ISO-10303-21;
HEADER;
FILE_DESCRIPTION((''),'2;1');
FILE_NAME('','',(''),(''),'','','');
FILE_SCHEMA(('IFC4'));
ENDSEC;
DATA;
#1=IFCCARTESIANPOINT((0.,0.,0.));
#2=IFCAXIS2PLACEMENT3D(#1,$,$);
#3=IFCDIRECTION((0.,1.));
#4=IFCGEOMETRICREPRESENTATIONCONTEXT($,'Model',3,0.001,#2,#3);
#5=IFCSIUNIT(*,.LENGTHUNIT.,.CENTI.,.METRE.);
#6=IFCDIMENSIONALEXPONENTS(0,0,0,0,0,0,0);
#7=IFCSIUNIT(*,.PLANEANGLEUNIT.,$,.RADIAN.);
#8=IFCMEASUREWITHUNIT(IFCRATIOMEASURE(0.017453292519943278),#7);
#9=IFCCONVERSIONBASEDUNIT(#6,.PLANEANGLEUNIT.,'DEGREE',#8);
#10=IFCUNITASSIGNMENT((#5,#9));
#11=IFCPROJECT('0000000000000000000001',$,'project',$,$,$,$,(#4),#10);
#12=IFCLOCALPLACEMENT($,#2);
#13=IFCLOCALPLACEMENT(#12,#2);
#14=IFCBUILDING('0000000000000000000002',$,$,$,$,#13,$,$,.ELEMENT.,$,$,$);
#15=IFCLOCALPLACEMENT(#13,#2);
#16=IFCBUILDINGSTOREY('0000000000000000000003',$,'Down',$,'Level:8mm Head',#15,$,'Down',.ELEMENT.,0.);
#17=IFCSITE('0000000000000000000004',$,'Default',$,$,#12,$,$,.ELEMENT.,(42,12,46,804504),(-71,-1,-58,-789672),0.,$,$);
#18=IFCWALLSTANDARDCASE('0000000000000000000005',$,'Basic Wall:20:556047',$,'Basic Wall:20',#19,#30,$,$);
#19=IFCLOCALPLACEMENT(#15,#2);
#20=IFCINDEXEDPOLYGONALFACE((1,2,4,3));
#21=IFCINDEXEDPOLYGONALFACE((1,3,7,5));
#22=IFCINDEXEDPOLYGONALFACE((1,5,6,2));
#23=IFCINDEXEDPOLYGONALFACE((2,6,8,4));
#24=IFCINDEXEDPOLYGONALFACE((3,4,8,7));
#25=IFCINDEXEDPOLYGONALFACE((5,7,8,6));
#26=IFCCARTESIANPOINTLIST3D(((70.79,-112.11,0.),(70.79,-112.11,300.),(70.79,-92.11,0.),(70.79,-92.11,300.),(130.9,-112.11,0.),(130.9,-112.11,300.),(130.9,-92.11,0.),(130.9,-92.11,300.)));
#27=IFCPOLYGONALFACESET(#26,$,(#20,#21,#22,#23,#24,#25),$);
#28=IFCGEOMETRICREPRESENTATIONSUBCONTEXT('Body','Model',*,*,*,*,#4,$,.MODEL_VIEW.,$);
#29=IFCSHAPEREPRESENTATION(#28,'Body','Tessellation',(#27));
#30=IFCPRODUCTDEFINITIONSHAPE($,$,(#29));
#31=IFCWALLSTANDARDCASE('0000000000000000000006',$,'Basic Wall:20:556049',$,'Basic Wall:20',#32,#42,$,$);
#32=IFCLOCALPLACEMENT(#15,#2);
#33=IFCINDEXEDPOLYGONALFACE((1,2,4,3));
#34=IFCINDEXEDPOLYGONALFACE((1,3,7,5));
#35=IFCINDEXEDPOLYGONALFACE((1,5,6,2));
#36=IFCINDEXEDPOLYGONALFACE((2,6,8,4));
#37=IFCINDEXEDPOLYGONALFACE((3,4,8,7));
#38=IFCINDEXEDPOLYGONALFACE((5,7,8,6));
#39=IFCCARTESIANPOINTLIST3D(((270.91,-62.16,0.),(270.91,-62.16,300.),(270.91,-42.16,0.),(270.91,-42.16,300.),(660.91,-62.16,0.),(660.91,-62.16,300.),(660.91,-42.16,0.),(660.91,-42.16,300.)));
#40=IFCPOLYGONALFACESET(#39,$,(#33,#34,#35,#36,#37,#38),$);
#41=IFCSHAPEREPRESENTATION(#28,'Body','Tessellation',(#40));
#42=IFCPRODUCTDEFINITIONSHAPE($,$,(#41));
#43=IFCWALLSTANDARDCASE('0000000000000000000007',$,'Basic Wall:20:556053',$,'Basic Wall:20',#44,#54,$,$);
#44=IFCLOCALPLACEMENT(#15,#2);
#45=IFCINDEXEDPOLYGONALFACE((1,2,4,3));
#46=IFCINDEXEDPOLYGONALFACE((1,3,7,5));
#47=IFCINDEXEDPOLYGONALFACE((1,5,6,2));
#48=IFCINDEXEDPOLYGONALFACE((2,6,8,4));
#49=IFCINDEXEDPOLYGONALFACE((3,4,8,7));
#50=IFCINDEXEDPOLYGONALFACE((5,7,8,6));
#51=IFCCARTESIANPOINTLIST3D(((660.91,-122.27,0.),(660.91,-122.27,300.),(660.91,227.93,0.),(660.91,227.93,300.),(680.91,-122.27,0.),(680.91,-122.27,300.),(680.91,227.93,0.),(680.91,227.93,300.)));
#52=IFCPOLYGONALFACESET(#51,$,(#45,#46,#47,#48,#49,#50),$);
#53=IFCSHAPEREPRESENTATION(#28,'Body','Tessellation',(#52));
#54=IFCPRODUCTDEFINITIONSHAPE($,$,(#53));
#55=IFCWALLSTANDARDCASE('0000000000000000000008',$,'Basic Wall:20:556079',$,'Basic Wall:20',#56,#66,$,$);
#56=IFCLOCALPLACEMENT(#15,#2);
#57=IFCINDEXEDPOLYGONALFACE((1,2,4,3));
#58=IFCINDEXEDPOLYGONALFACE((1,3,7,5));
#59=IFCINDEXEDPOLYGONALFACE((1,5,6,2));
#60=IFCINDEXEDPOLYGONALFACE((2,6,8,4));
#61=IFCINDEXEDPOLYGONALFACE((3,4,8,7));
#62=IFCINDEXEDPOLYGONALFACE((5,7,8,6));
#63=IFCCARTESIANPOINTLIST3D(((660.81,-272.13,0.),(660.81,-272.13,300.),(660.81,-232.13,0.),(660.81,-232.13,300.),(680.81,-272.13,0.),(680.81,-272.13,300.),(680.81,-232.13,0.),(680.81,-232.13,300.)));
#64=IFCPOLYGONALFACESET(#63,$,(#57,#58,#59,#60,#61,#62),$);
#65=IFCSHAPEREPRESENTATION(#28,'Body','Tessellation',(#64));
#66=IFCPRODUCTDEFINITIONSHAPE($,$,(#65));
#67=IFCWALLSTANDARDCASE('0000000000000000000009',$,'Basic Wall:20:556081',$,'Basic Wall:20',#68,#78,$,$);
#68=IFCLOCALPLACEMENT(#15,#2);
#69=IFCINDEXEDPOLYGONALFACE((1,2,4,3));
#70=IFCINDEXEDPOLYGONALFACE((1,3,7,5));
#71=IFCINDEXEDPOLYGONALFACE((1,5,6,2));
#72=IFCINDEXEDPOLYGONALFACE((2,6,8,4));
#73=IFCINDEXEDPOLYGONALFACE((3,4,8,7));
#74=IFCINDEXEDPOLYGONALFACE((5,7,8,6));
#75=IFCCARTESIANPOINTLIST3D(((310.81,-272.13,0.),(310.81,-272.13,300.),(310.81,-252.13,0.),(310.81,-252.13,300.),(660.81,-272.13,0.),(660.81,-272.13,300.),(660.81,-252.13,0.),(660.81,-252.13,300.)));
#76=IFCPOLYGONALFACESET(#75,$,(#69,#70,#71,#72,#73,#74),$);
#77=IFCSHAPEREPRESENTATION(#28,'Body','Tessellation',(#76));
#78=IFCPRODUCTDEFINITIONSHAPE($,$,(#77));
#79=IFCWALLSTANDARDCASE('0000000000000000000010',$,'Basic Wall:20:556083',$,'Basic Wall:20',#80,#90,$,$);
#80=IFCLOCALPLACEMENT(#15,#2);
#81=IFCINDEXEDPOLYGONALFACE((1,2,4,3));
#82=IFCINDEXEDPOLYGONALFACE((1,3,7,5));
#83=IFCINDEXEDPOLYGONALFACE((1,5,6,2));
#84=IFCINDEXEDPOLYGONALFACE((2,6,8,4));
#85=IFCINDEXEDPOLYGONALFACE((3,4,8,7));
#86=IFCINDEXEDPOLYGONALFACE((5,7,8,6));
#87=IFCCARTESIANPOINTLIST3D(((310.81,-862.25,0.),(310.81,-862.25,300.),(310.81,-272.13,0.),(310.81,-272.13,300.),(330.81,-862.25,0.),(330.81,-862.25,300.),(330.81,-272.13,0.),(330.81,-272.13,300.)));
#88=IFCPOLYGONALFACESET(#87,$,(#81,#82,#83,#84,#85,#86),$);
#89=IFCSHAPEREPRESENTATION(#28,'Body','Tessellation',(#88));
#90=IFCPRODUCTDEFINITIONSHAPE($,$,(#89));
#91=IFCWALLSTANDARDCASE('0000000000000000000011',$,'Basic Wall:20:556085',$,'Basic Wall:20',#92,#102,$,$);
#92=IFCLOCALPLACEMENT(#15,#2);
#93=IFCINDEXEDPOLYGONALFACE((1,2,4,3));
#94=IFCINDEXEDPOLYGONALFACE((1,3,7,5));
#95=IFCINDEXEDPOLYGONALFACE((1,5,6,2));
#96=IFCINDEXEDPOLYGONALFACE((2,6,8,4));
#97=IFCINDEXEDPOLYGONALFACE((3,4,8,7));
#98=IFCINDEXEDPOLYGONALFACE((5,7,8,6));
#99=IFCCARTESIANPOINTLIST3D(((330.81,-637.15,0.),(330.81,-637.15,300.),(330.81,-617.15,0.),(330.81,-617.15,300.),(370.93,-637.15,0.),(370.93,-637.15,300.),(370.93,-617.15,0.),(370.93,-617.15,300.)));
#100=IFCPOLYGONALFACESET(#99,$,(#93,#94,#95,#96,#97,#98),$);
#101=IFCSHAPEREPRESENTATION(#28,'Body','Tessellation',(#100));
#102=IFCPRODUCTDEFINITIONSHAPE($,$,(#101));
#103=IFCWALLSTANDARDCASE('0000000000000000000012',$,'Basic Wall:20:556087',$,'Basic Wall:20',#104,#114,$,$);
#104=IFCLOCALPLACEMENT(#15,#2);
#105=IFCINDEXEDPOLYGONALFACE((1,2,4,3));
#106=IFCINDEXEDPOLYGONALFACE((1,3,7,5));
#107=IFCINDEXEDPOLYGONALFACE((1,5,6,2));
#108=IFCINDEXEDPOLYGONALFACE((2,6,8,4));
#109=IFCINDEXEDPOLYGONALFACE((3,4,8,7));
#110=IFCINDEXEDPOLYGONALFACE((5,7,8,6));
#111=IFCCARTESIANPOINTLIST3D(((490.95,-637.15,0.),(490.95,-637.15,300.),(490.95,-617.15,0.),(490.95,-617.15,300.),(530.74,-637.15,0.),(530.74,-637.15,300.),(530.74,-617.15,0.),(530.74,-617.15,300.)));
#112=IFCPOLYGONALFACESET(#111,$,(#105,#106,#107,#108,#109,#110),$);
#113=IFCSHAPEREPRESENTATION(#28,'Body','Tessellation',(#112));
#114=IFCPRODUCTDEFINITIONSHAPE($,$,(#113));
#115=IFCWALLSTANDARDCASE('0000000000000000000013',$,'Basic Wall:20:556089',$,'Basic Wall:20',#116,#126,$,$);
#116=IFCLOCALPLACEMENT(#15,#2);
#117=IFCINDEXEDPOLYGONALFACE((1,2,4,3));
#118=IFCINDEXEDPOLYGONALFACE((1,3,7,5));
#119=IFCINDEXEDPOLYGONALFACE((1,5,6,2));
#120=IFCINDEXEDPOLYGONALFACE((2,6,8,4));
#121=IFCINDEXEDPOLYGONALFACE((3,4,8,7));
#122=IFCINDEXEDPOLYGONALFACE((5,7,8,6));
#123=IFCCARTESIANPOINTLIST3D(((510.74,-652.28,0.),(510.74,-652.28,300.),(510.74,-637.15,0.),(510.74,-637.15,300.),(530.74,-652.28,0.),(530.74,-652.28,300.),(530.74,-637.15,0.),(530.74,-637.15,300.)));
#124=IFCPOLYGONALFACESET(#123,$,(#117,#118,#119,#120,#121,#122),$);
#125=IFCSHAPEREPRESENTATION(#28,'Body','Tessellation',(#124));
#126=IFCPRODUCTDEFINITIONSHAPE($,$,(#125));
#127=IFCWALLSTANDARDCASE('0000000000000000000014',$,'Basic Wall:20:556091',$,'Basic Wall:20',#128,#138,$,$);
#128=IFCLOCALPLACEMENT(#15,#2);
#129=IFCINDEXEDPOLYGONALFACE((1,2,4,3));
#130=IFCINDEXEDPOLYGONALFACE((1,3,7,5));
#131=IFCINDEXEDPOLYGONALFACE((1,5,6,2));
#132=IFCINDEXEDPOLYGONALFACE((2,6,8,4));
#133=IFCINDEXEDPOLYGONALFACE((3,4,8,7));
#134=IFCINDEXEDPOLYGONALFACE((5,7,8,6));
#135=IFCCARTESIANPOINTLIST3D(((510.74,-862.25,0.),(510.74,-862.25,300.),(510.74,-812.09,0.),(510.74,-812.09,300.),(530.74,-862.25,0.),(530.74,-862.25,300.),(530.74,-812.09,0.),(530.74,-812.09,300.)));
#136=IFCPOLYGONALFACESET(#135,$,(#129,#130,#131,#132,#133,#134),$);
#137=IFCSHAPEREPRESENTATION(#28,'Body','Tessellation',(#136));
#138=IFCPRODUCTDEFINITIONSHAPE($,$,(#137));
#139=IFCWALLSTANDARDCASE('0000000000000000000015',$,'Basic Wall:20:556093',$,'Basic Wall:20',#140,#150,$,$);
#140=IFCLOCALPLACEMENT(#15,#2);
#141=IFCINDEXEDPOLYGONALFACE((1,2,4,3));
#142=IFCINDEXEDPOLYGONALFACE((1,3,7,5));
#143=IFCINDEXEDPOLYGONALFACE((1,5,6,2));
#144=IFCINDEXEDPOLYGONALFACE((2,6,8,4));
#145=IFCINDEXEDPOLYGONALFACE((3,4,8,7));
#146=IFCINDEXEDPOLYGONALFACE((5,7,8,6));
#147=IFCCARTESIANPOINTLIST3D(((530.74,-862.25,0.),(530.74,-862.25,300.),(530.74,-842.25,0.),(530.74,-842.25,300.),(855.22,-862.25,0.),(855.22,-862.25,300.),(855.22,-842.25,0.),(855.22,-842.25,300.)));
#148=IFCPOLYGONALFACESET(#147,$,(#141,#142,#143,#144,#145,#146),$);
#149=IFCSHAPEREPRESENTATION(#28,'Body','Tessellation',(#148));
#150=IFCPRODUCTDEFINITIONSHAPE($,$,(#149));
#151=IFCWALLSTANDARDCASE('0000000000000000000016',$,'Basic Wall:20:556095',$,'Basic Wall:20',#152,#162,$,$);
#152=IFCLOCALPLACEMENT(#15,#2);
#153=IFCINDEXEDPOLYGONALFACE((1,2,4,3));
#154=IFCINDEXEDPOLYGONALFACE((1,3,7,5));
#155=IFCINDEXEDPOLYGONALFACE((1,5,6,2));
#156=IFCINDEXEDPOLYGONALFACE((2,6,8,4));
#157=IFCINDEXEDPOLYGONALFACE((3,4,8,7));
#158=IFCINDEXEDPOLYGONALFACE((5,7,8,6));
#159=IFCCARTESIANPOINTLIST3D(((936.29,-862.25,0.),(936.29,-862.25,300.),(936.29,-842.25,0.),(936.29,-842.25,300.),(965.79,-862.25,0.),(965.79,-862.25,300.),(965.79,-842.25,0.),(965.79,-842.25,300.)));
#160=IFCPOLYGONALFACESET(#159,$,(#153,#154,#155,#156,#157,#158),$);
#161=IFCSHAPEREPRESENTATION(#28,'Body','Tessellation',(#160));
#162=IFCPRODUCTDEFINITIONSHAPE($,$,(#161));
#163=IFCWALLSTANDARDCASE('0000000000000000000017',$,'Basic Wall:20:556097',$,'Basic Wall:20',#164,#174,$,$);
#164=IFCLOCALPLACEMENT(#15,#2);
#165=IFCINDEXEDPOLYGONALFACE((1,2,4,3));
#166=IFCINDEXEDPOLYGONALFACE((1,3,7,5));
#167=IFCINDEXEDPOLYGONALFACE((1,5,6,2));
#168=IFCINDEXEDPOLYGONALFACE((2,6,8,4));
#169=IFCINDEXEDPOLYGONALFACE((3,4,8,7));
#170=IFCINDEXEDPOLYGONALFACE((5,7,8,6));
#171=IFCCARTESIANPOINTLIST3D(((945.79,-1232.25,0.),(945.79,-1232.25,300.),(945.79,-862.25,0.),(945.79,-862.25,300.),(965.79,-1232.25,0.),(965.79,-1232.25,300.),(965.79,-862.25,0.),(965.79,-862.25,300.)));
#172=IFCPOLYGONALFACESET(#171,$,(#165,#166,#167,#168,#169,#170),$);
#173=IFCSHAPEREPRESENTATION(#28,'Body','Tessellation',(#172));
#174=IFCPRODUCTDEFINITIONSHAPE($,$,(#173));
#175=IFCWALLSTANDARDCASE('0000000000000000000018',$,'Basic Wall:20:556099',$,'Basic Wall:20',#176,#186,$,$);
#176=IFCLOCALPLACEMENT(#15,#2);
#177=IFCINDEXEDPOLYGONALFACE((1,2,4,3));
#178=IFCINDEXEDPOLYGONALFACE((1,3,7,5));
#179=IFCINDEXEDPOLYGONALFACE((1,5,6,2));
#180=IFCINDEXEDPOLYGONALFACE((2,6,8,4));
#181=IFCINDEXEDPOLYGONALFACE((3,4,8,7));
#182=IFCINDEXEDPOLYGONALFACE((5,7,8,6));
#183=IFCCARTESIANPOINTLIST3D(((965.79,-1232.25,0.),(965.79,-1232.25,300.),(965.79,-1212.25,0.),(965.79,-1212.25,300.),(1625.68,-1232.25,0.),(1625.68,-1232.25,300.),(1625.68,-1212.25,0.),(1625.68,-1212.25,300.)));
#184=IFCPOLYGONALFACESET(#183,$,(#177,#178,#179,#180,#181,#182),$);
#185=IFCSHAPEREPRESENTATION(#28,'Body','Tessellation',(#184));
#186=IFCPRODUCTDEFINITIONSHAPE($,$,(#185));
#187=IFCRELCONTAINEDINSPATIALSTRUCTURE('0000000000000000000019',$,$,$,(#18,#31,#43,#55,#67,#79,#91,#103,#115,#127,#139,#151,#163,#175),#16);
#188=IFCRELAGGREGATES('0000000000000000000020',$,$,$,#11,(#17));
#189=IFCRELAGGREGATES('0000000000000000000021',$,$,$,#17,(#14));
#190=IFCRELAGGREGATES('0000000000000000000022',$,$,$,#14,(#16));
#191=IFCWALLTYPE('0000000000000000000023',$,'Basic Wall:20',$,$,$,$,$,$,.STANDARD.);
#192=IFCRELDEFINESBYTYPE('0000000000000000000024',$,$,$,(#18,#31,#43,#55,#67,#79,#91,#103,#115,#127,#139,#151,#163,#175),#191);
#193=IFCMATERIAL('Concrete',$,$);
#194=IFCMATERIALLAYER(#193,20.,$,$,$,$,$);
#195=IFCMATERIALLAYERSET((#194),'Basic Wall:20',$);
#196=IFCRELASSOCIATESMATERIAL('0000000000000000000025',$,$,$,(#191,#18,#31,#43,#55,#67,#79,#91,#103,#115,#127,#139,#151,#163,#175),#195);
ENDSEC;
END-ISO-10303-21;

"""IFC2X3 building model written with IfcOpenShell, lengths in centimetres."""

from ifc_helpers import new_model, entity, si_unit, converted_unit, direction, frame, frame_2d, origin, place, context, subcontext, project, spatial, rectangle, extrude, material, layer, layer_set, layer_usage, type_object, element, save


model = new_model("IFC2X3")

# Units and contexts
model_context = context("Model", 3, precision=0.001, world=origin(), true_north=direction((0.0, 1.0)))
body_context = subcontext(model_context, "Body", "Model", "MODEL_VIEW")
ifc_project = project(units=[si_unit("LENGTHUNIT", "METRE", prefix="CENTI"), converted_unit("PLANEANGLEUNIT", "DEGREE", entity("IfcRatioMeasure", 0.017453292519943278), si_unit("PLANEANGLEUNIT", "RADIAN"), dimensions=[0, 0, 0, 0, 0, 0, 0])], contexts=[model_context])

# Site, building, storey
site_placement = place(None, origin())
site = spatial("IfcSite", under=ifc_project, at=site_placement, Name="Default", CompositionType="ELEMENT", RefLatitude=(42, 12, 46, 804504), RefLongitude=(-71, -1, -58, -789672), RefElevation=0.0)
building_placement = place(site_placement, origin())
building = spatial("IfcBuilding", under=site, at=building_placement, CompositionType="ELEMENT")
storey_placement = place(building_placement, origin())
storey = spatial("IfcBuildingStorey", under=building, at=storey_placement, Name="Down", ObjectType="Level:8mm Head", LongName="Down", CompositionType="ELEMENT", Elevation=0.0)

# Walls
ifc_material = material(Name="Concrete")
ifc_layer_1 = layer(ifc_material, 20.0)
ifc_layer_set_1 = layer_set([ifc_layer_1], Name="Basic Wall:20")
ifc_layer_usage_1 = layer_usage(ifc_layer_set_1, "AXIS2", "NEGATIVE", 10.0)
wall_type_1 = type_object("IfcWallType", Name="Basic Wall:20", PredefinedType="STANDARD", material=ifc_layer_set_1)
wall_1_placement = place(storey_placement, frame((130.9, -102.11, 0.0), z_axis=(0.0, 0.0, 1.0), x_axis=(-1.0, 0.0, 0.0)))
element("IfcWallStandardCase", 1, at=wall_1_placement, inside=storey, type_object=wall_type_1, material=ifc_layer_usage_1, Name="Basic Wall:20:556047", ObjectType="Basic Wall:20", context=body_context, shape_type="SweptSolid", body=[
    extrude(rectangle(XDim=60.11, YDim=20.0, at=frame_2d((30.06, 0.0), x_axis=(-1.0, 0.0))), origin(), (0.0, 0.0, 1.0), 300.0),
])
ifc_layer_usage_2 = layer_usage(ifc_layer_set_1, "AXIS2", "POSITIVE", -10.0)
wall_2_placement = place(storey_placement, frame((270.91, -52.16, 0.0)))
element("IfcWallStandardCase", 2, at=wall_2_placement, inside=storey, type_object=wall_type_1, material=ifc_layer_usage_2, Name="Basic Wall:20:556049", ObjectType="Basic Wall:20", context=body_context, shape_type="SweptSolid", body=[
    extrude(rectangle(XDim=390.0, YDim=20.0, at=frame_2d((195.0, 0.0), x_axis=(-1.0, 0.0))), origin(), (0.0, 0.0, 1.0), 300.0),
])
ifc_layer_usage_3 = layer_usage(ifc_layer_set_1, "AXIS2", "POSITIVE", -10.0)
wall_3_placement = place(storey_placement, frame((670.91, -122.27, 0.0), z_axis=(0.0, 0.0, 1.0), x_axis=(0.0, 1.0, 0.0)))
element("IfcWallStandardCase", 3, at=wall_3_placement, inside=storey, type_object=wall_type_1, material=ifc_layer_usage_3, Name="Basic Wall:20:556053", ObjectType="Basic Wall:20", context=body_context, shape_type="SweptSolid", body=[
    extrude(rectangle(XDim=350.2, YDim=20.0, at=frame_2d((175.1, 0.0), x_axis=(-1.0, 0.0))), origin(), (0.0, 0.0, 1.0), 300.0),
])
ifc_layer_usage_4 = layer_usage(ifc_layer_set_1, "AXIS2", "NEGATIVE", 10.0)
wall_4_placement = place(storey_placement, frame((670.81, -232.13, 0.0), z_axis=(0.0, 0.0, 1.0), x_axis=(0.0, -1.0, 0.0)))
element("IfcWallStandardCase", 4, at=wall_4_placement, inside=storey, type_object=wall_type_1, material=ifc_layer_usage_4, Name="Basic Wall:20:556079", ObjectType="Basic Wall:20", context=body_context, shape_type="SweptSolid", body=[
    extrude(rectangle(XDim=40.0, YDim=20.0, at=frame_2d((20.0, 0.0), x_axis=(-1.0, 0.0))), origin(), (0.0, 0.0, 1.0), 300.0),
])
ifc_layer_usage_5 = layer_usage(ifc_layer_set_1, "AXIS2", "NEGATIVE", 10.0)
wall_5_placement = place(storey_placement, frame((660.81, -262.13, 0.0), z_axis=(0.0, 0.0, 1.0), x_axis=(-1.0, 0.0, 0.0)))
element("IfcWallStandardCase", 5, at=wall_5_placement, inside=storey, type_object=wall_type_1, material=ifc_layer_usage_5, Name="Basic Wall:20:556081", ObjectType="Basic Wall:20", context=body_context, shape_type="SweptSolid", body=[
    extrude(rectangle(XDim=350.0, YDim=20.0, at=frame_2d((175.0, 0.0), x_axis=(-1.0, 0.0))), origin(), (0.0, 0.0, 1.0), 300.0),
])
ifc_layer_usage_6 = layer_usage(ifc_layer_set_1, "AXIS2", "POSITIVE", -10.0)
wall_6_placement = place(storey_placement, frame((320.81, -272.13, 0.0), z_axis=(0.0, 0.0, 1.0), x_axis=(0.0, -1.0, 0.0)))
element("IfcWallStandardCase", 6, at=wall_6_placement, inside=storey, type_object=wall_type_1, material=ifc_layer_usage_6, Name="Basic Wall:20:556083", ObjectType="Basic Wall:20", context=body_context, shape_type="SweptSolid", body=[
    extrude(rectangle(XDim=590.12, YDim=20.0, at=frame_2d((295.06, 0.0), x_axis=(-1.0, 0.0))), origin(), (0.0, 0.0, 1.0), 300.0),
])
ifc_layer_usage_7 = layer_usage(ifc_layer_set_1, "AXIS2", "NEGATIVE", 10.0)
wall_7_placement = place(storey_placement, frame((330.81, -627.15, 0.0)))
element("IfcWallStandardCase", 7, at=wall_7_placement, inside=storey, type_object=wall_type_1, material=ifc_layer_usage_7, Name="Basic Wall:20:556085", ObjectType="Basic Wall:20", context=body_context, shape_type="SweptSolid", body=[
    extrude(rectangle(XDim=40.12, YDim=20.0, at=frame_2d((20.06, 0.0), x_axis=(-1.0, 0.0))), origin(), (0.0, 0.0, 1.0), 300.0),
])
ifc_layer_usage_8 = layer_usage(ifc_layer_set_1, "AXIS2", "NEGATIVE", 10.0)
wall_8_placement = place(storey_placement, frame((490.95, -627.15, 0.0)))
element("IfcWallStandardCase", 8, at=wall_8_placement, inside=storey, type_object=wall_type_1, material=ifc_layer_usage_8, Name="Basic Wall:20:556087", ObjectType="Basic Wall:20", context=body_context, shape_type="SweptSolid", body=[
    extrude(rectangle(XDim=39.79, YDim=20.0, at=frame_2d((19.9, 0.0), x_axis=(-1.0, 0.0))), origin(), (0.0, 0.0, 1.0), 300.0),
])
ifc_layer_usage_9 = layer_usage(ifc_layer_set_1, "AXIS2", "NEGATIVE", 10.0)
wall_9_placement = place(storey_placement, frame((520.74, -637.15, 0.0), z_axis=(0.0, 0.0, 1.0), x_axis=(0.0, -1.0, 0.0)))
element("IfcWallStandardCase", 9, at=wall_9_placement, inside=storey, type_object=wall_type_1, material=ifc_layer_usage_9, Name="Basic Wall:20:556089", ObjectType="Basic Wall:20", context=body_context, shape_type="SweptSolid", body=[
    extrude(rectangle(XDim=15.14, YDim=20.0, at=frame_2d((7.57, 0.0), x_axis=(-1.0, 0.0))), origin(), (0.0, 0.0, 1.0), 300.0),
])
ifc_layer_usage_10 = layer_usage(ifc_layer_set_1, "AXIS2", "NEGATIVE", 10.0)
wall_10_placement = place(storey_placement, frame((520.74, -812.09, 0.0), z_axis=(0.0, 0.0, 1.0), x_axis=(0.0, -1.0, 0.0)))
element("IfcWallStandardCase", 10, at=wall_10_placement, inside=storey, type_object=wall_type_1, material=ifc_layer_usage_10, Name="Basic Wall:20:556091", ObjectType="Basic Wall:20", context=body_context, shape_type="SweptSolid", body=[
    extrude(rectangle(XDim=50.16, YDim=20.0, at=frame_2d((25.08, 0.0), x_axis=(-1.0, 0.0))), origin(), (0.0, 0.0, 1.0), 300.0),
])
ifc_layer_usage_11 = layer_usage(ifc_layer_set_1, "AXIS2", "POSITIVE", -10.0)
wall_11_placement = place(storey_placement, frame((530.74, -852.25, 0.0)))
element("IfcWallStandardCase", 11, at=wall_11_placement, inside=storey, type_object=wall_type_1, material=ifc_layer_usage_11, Name="Basic Wall:20:556093", ObjectType="Basic Wall:20", context=body_context, shape_type="SweptSolid", body=[
    extrude(rectangle(XDim=324.48, YDim=20.0, at=frame_2d((162.24, 0.0), x_axis=(-1.0, 0.0))), origin(), (0.0, 0.0, 1.0), 300.0),
])
ifc_layer_usage_12 = layer_usage(ifc_layer_set_1, "AXIS2", "POSITIVE", -10.0)
wall_12_placement = place(storey_placement, frame((936.29, -852.25, 0.0)))
element("IfcWallStandardCase", 12, at=wall_12_placement, inside=storey, type_object=wall_type_1, material=ifc_layer_usage_12, Name="Basic Wall:20:556095", ObjectType="Basic Wall:20", context=body_context, shape_type="SweptSolid", body=[
    extrude(rectangle(XDim=29.5, YDim=20.0, at=frame_2d((14.75, 0.0), x_axis=(-1.0, 0.0))), origin(), (0.0, 0.0, 1.0), 300.0),
])
ifc_layer_usage_13 = layer_usage(ifc_layer_set_1, "AXIS2", "NEGATIVE", 10.0)
wall_13_placement = place(storey_placement, frame((955.79, -862.25, 0.0), z_axis=(0.0, 0.0, 1.0), x_axis=(0.0, -1.0, 0.0)))
element("IfcWallStandardCase", 13, at=wall_13_placement, inside=storey, type_object=wall_type_1, material=ifc_layer_usage_13, Name="Basic Wall:20:556097", ObjectType="Basic Wall:20", context=body_context, shape_type="SweptSolid", body=[
    extrude(rectangle(XDim=369.99, YDim=20.0, at=frame_2d((185.0, 0.0), x_axis=(-1.0, 0.0))), origin(), (0.0, 0.0, 1.0), 300.0),
])
ifc_layer_usage_14 = layer_usage(ifc_layer_set_1, "AXIS2", "POSITIVE", -10.0)
wall_14_placement = place(storey_placement, frame((965.79, -1222.25, 0.0)))
element("IfcWallStandardCase", 14, at=wall_14_placement, inside=storey, type_object=wall_type_1, material=ifc_layer_usage_14, Name="Basic Wall:20:556099", ObjectType="Basic Wall:20", context=body_context, shape_type="SweptSolid", body=[
    extrude(rectangle(XDim=659.89, YDim=20.0, at=frame_2d((329.95, 0.0), x_axis=(-1.0, 0.0))), origin(), (0.0, 0.0, 1.0), 300.0),
])

save(model, "model.ifc")
